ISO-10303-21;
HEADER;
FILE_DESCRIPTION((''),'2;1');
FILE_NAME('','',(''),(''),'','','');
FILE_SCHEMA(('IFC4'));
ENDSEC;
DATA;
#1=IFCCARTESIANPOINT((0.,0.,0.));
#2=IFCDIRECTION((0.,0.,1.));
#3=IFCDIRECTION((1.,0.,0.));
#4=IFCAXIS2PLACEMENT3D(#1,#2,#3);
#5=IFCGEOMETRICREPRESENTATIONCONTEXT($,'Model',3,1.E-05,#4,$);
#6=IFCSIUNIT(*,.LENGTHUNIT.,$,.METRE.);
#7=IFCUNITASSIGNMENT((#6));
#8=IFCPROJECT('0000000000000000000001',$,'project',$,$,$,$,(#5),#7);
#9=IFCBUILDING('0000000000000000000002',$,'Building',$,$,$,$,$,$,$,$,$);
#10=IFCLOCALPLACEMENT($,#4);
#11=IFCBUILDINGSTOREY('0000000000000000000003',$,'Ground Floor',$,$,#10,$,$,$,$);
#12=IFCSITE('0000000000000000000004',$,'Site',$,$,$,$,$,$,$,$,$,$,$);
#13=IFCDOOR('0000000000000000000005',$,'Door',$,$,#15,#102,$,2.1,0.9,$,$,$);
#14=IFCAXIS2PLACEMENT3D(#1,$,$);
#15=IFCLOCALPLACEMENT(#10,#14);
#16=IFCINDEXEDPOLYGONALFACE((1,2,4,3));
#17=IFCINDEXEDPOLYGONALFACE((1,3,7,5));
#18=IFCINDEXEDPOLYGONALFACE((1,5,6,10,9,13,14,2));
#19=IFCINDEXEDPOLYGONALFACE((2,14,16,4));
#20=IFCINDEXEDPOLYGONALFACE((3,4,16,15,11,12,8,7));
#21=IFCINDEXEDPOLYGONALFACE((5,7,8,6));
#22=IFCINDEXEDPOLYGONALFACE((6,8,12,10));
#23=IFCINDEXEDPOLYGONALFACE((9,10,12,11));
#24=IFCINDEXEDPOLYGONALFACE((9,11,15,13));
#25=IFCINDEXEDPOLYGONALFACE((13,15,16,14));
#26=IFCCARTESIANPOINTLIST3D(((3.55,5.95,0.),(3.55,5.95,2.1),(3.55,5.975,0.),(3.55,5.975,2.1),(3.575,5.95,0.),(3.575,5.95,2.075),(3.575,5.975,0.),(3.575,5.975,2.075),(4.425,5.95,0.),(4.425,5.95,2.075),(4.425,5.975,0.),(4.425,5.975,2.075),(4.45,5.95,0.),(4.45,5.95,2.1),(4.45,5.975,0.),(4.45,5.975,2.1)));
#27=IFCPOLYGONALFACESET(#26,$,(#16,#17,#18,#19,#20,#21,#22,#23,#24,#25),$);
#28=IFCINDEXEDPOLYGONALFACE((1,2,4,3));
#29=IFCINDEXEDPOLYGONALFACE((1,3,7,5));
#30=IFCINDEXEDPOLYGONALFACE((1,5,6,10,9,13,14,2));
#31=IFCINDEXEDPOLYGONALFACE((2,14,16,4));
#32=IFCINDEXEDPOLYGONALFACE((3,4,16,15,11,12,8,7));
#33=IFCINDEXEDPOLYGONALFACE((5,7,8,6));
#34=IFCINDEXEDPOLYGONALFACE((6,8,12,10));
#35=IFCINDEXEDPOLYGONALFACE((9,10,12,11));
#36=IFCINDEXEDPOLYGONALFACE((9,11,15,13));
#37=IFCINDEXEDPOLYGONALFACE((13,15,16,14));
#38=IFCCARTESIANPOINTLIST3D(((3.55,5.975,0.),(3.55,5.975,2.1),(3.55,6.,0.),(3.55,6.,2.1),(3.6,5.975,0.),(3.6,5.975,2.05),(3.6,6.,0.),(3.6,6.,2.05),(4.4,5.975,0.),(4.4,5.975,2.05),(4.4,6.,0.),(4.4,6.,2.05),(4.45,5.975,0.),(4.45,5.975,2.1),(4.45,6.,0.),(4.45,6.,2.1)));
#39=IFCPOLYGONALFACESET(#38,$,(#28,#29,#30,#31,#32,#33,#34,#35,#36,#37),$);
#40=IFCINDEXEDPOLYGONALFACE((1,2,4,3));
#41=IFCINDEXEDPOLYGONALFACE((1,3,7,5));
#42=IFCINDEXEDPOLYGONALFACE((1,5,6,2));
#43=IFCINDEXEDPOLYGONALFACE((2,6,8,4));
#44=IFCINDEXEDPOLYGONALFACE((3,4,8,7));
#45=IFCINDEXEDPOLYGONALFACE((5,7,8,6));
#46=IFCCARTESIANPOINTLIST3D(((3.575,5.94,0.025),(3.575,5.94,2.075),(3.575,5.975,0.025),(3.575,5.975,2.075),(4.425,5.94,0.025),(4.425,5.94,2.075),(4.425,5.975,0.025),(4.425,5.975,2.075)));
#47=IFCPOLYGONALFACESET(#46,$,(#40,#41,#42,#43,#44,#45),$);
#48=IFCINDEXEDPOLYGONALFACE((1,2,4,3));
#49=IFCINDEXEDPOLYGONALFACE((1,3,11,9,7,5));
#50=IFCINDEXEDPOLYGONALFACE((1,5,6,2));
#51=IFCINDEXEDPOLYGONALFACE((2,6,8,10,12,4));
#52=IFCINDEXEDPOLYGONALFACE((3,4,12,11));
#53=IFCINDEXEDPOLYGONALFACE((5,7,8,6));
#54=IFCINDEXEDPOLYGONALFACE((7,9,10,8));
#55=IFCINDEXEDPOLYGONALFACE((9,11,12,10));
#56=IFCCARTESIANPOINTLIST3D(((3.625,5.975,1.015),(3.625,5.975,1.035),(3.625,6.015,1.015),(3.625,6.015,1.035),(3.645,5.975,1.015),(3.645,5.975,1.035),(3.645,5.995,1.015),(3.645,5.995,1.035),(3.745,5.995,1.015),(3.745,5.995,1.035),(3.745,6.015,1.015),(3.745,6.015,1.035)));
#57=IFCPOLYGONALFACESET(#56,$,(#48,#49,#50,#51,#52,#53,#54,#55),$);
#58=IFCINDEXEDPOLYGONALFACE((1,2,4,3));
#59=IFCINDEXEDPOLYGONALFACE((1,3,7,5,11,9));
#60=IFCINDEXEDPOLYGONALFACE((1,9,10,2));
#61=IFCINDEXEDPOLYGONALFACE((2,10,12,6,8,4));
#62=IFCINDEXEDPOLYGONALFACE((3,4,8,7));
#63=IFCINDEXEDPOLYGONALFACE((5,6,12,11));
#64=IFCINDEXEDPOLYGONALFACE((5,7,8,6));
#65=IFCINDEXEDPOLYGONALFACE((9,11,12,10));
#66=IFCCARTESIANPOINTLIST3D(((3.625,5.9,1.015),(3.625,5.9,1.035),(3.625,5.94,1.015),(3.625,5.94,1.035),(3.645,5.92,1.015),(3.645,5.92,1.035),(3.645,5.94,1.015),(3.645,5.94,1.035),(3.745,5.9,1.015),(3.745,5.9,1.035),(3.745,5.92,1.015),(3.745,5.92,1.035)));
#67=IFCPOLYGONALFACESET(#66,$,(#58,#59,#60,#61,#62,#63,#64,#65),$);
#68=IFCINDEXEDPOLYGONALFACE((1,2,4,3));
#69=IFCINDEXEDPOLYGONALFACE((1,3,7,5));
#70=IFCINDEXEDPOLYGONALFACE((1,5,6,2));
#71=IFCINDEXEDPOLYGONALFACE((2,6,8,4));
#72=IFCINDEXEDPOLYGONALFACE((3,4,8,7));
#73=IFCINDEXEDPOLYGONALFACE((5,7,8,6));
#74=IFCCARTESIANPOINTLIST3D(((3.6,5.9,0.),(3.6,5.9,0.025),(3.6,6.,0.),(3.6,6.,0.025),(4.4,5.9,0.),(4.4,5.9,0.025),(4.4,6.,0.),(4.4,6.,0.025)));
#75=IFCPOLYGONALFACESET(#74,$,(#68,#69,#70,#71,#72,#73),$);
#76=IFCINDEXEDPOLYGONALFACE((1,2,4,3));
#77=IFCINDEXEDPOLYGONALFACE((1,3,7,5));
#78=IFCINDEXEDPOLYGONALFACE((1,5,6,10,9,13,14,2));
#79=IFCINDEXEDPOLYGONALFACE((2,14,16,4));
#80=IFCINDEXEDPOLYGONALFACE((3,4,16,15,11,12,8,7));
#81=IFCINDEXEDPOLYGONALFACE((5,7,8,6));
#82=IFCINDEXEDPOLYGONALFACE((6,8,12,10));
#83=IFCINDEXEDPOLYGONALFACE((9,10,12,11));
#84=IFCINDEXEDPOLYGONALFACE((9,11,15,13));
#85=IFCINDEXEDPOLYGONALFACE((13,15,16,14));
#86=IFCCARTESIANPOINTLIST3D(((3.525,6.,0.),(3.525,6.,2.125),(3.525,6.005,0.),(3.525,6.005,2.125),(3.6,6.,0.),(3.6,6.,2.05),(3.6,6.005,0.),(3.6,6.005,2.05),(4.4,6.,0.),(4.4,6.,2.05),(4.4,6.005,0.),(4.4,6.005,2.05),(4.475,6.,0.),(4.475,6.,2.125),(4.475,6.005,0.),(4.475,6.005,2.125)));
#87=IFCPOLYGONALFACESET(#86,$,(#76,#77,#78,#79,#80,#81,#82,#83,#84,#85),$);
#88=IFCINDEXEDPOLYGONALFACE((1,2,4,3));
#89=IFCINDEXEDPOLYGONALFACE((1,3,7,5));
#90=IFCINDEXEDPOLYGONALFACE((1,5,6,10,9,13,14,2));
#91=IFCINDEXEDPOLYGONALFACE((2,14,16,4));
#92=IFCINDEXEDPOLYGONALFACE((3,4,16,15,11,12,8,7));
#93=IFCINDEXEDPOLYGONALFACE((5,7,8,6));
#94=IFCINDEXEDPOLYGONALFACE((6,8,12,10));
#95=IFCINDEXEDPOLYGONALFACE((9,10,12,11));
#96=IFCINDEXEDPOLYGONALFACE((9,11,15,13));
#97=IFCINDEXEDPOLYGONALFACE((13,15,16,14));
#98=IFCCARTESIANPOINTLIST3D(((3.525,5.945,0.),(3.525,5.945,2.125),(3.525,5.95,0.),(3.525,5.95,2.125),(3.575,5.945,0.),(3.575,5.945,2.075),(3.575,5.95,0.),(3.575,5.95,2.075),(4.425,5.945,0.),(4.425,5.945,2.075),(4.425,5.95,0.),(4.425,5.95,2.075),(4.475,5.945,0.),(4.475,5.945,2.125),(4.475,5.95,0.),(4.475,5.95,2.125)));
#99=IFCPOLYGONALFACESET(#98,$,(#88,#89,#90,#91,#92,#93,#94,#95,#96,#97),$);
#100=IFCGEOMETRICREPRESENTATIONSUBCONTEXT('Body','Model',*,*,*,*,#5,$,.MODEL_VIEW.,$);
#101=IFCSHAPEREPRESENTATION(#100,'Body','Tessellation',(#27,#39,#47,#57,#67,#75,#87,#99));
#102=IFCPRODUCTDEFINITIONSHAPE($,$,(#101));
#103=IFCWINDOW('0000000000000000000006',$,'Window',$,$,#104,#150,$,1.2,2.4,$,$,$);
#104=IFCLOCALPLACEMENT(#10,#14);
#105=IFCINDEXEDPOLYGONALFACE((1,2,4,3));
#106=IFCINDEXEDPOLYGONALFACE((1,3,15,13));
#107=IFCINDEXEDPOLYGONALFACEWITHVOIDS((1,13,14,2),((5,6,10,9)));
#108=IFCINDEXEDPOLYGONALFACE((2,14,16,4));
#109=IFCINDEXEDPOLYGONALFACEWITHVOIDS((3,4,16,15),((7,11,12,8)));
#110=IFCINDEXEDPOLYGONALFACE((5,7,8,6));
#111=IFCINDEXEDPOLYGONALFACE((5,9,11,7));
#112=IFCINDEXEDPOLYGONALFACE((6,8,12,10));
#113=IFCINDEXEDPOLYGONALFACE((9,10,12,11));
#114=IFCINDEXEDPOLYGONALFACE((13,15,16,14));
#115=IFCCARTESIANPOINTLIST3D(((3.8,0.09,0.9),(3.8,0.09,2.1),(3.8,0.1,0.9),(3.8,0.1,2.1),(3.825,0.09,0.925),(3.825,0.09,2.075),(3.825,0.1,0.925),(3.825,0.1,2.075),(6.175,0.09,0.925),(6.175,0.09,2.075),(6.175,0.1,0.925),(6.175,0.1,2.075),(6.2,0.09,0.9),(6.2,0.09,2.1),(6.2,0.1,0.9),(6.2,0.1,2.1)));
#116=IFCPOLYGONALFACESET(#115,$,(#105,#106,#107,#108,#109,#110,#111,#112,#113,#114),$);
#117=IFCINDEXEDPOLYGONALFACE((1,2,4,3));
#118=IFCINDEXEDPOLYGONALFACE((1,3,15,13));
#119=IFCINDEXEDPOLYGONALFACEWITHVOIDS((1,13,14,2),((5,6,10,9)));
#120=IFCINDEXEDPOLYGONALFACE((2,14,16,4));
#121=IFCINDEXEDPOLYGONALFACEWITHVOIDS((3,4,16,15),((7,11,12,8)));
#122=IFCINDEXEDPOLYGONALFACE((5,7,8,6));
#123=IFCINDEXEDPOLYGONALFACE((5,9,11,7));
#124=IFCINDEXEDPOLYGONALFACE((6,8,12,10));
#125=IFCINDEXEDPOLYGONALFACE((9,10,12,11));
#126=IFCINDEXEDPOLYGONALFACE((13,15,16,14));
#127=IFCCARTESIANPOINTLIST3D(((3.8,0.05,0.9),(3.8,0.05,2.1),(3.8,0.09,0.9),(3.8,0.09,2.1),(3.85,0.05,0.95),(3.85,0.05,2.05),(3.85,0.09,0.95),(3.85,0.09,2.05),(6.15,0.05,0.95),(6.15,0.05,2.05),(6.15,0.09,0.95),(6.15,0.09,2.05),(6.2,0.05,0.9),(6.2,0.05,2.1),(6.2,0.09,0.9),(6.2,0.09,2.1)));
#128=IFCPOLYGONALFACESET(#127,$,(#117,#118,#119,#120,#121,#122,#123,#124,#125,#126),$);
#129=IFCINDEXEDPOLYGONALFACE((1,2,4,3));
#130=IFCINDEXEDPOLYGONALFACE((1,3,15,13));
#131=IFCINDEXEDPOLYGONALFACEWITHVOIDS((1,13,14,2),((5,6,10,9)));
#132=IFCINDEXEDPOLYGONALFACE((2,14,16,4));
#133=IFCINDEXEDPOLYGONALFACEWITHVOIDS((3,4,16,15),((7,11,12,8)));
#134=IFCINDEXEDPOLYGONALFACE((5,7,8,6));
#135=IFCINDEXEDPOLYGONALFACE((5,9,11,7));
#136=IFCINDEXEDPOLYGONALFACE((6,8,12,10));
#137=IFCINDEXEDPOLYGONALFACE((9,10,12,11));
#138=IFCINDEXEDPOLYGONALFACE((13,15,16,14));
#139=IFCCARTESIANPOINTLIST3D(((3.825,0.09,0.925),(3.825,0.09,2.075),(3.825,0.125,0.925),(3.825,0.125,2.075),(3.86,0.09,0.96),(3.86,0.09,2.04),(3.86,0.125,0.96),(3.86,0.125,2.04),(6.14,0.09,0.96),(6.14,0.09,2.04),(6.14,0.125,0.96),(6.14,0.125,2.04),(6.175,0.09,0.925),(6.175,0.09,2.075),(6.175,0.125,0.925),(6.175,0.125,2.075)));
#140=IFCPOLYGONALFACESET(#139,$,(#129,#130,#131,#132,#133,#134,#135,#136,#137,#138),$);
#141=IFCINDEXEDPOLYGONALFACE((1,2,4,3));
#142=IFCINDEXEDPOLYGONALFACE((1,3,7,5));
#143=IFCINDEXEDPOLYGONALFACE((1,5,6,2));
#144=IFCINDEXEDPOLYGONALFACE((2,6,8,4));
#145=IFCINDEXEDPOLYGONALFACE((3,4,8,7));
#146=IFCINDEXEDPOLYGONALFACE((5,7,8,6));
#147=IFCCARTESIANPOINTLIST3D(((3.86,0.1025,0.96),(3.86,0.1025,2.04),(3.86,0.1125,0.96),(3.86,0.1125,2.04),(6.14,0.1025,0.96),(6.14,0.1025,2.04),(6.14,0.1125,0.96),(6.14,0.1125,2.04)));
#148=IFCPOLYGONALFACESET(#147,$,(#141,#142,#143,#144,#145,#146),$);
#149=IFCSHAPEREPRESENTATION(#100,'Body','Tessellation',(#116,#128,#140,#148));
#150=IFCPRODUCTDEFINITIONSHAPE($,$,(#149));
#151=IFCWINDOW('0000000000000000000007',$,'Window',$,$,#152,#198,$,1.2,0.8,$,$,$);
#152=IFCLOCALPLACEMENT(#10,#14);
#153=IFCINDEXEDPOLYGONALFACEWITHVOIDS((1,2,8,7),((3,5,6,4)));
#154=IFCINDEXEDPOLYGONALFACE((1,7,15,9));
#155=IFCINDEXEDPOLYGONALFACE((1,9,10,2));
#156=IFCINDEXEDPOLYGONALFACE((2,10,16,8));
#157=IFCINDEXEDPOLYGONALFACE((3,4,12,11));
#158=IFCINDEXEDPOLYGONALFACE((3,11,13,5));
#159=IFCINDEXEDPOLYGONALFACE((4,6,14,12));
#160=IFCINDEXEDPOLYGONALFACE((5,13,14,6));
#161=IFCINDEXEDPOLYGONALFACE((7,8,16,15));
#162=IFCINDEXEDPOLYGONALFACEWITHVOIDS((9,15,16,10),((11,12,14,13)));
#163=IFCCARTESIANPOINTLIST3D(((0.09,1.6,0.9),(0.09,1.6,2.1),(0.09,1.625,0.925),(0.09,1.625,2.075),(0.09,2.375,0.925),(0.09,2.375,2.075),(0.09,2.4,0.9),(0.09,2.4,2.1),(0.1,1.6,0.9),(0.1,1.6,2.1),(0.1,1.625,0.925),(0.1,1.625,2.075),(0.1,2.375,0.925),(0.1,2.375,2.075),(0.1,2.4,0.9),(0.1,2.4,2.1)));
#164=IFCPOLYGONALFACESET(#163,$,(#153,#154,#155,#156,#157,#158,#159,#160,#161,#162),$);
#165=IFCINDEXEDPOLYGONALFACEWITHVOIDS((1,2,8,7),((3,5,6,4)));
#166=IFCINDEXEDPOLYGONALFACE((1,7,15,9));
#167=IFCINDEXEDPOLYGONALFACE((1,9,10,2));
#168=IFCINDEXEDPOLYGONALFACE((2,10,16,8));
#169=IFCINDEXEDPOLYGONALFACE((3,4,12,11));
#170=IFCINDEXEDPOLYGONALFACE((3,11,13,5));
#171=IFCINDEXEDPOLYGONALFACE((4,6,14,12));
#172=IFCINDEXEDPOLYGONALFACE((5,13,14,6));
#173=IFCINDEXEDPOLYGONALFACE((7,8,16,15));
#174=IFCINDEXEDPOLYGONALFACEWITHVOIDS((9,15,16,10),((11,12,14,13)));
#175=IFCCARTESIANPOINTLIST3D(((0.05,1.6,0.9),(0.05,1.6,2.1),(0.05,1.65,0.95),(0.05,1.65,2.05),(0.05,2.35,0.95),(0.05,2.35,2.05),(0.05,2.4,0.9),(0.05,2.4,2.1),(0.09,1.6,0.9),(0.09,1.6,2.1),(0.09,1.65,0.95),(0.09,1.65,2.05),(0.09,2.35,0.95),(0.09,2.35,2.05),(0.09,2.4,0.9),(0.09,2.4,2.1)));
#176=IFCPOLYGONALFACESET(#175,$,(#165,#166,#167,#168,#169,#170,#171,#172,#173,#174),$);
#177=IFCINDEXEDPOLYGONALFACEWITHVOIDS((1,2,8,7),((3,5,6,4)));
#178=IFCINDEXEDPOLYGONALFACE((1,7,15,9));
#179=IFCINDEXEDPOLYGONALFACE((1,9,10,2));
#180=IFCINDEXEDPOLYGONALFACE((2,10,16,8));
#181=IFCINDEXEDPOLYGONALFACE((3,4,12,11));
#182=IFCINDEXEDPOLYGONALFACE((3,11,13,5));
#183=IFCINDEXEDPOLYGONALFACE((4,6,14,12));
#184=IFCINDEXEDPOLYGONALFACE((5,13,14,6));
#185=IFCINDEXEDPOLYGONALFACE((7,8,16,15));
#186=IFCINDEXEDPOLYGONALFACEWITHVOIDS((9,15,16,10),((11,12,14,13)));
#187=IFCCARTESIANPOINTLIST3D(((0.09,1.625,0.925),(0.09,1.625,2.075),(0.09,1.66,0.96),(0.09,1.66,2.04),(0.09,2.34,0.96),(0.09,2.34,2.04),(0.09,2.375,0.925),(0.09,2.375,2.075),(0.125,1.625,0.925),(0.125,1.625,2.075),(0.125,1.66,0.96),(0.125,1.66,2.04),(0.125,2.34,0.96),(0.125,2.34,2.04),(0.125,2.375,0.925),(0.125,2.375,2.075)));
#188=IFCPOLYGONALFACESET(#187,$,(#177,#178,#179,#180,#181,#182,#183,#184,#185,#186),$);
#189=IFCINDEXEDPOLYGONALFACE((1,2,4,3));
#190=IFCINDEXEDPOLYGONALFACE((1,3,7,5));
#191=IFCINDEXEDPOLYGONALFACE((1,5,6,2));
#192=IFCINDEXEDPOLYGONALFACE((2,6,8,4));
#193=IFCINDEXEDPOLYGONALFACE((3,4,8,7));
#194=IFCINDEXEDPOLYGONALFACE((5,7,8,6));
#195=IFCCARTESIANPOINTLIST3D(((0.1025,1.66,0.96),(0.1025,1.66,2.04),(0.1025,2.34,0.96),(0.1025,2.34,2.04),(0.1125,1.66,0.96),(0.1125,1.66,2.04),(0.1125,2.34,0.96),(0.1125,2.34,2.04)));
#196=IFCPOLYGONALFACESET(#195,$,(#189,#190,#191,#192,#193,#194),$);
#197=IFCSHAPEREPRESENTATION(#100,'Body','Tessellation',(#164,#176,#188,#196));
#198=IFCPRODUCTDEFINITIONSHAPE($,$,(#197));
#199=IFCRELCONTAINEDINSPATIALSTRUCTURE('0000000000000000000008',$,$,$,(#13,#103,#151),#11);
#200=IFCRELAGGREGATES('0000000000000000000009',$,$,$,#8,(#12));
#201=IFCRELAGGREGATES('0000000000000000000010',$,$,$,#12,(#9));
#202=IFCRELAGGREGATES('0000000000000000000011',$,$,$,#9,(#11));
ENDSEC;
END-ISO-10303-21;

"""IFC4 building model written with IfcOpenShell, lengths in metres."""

from ifc_helpers import new_model, si_unit, frame, origin_with_axes, place, context, subcontext, project, spatial, line, indexed_curve, outline, extrude, element, save


model = new_model("IFC4")

# Units and contexts
model_context = context("Model", 3, precision=1e-05, world=origin_with_axes())
body_context = subcontext(model_context, "Body", "Model", "MODEL_VIEW")
ifc_project = project(units=[si_unit("LENGTHUNIT", "METRE")], contexts=[model_context])

# Site, building, storey
site = spatial("IfcSite", under=ifc_project, Name="Site")
building = spatial("IfcBuilding", under=site, Name="Building")
storey_placement = place(None, origin_with_axes())
storey = spatial("IfcBuildingStorey", under=building, at=storey_placement, Name="Ground Floor")

# Door
door_1_placement = place(storey_placement, frame((4.45, 6.0, 0.0), z_axis=(0.0, 0.0, 1.0), x_axis=(-1.0, 0.0, 0.0)))
element("IfcDoor", 1, at=door_1_placement, inside=storey, Name="Door", OverallHeight=2.1, OverallWidth=0.9, context=body_context, shape_type="SweptSolid", body=[
    extrude(outline(indexed_curve([(0.0, 0.0), (0.0, 2.1), (0.9, 2.1), (0.9, 0.0), (0.875, 0.0), (0.875, 2.075), (0.025, 2.075), (0.025, 0.0)], segments=[line(1, 2, 3, 4, 5, 6, 7, 8, 1)])), frame((0.0, 0.025, 0.0), z_axis=(0.0, -1.0, 0.0), x_axis=(1.0, 0.0, 0.0)), (0.0, 0.0, -1.0), 0.025),
    extrude(outline(indexed_curve([(0.0, 0.0), (0.0, 2.1), (0.9, 2.1), (0.9, 0.0), (0.85, 0.0), (0.85, 2.05), (0.05, 2.05), (0.05, 0.0)], segments=[line(1, 2, 3, 4, 5, 6, 7, 8, 1)])), frame((0.0, 0.0, 0.0), z_axis=(0.0, -1.0, 0.0), x_axis=(1.0, 0.0, 0.0)), (0.0, 0.0, -1.0), 0.025),
    extrude(outline(indexed_curve([(0.0, 0.0), (0.85, 0.0), (0.85, 0.035), (0.0, 0.035)], segments=[line(1, 2, 3, 4, 1)])), frame((0.025, 0.025, 0.025), z_axis=(0.0, 0.0, 1.0), x_axis=(1.0, 0.0, 0.0)), (0.0, 0.0, 1.0), 2.05),
    extrude(outline(indexed_curve([(0.0, 0.0), (0.0, -0.04), (-0.12, -0.04), (-0.12, -0.02), (-0.02, -0.02), (-0.02, 0.0)], segments=[line(1, 2, 3, 4, 5, 6, 1)])), frame((0.825, 0.025, 1.015), z_axis=(0.0, 0.0, 1.0), x_axis=(1.0, 0.0, 0.0)), (0.0, 0.0, 1.0), 0.02),
    extrude(outline(indexed_curve([(0.0, 0.0), (0.0, 0.04), (-0.12, 0.04), (-0.12, 0.02), (-0.02, 0.02), (-0.02, 0.0)], segments=[line(1, 2, 3, 4, 5, 6, 1)])), frame((0.825, 0.06, 1.015), z_axis=(0.0, 0.0, 1.0), x_axis=(1.0, 0.0, 0.0)), (0.0, 0.0, 1.0), 0.02),
    extrude(outline(indexed_curve([(0.0, 0.0), (0.8, 0.0), (0.8, 0.1), (0.0, 0.1)], segments=[line(1, 2, 3, 4, 1)])), frame((0.05, 0.0, 0.0), z_axis=(0.0, 0.0, 1.0), x_axis=(1.0, 0.0, 0.0)), (0.0, 0.0, 1.0), 0.025),
    extrude(outline(indexed_curve([(0.0, 0.0), (0.0, 2.125), (0.95, 2.125), (0.95, 0.0), (0.875, 0.0), (0.875, 2.05), (0.075, 2.05), (0.075, 0.0)], segments=[line(1, 2, 3, 4, 5, 6, 7, 8, 1)])), frame((-0.025, -0.005, 0.0), z_axis=(0.0, -1.0, 0.0), x_axis=(1.0, 0.0, 0.0)), (0.0, 0.0, -1.0), 0.005),
    extrude(outline(indexed_curve([(0.0, 0.0), (0.0, 2.125), (0.95, 2.125), (0.95, 0.0), (0.9, 0.0), (0.9, 2.075), (0.05, 2.075), (0.05, 0.0)], segments=[line(1, 2, 3, 4, 5, 6, 7, 8, 1)])), frame((-0.025, 0.05, 0.0), z_axis=(0.0, -1.0, 0.0), x_axis=(1.0, 0.0, 0.0)), (0.0, 0.0, -1.0), 0.005),
])

# Windows
window_1_placement = place(storey_placement, frame((3.8, 0.0, 0.9), z_axis=(0.0, 0.0, 1.0), x_axis=(1.0, 0.0, 0.0)))
element("IfcWindow", 2, at=window_1_placement, inside=storey, Name="Window", OverallHeight=1.2, OverallWidth=2.4, context=body_context, shape_type="SweptSolid", body=[
    extrude(outline(indexed_curve([(0.0, 0.0), (2.4, 0.0), (2.4, 1.2), (0.0, 1.2)], segments=[line(1, 2, 3, 4, 1)]), holes=[indexed_curve([(0.025, 0.025), (2.375, 0.025), (2.375, 1.175), (0.025, 1.175)], segments=[line(1, 2, 3, 4, 1)])]), frame((0.0, 0.09, 0.0), z_axis=(0.0, -1.0, 0.0), x_axis=(1.0, 0.0, 0.0)), (0.0, 0.0, -1.0), 0.01),
    extrude(outline(indexed_curve([(0.0, 0.0), (2.4, 0.0), (2.4, 1.2), (0.0, 1.2)], segments=[line(1, 2, 3, 4, 1)]), holes=[indexed_curve([(0.05, 0.05), (2.35, 0.05), (2.35, 1.15), (0.05, 1.15)], segments=[line(1, 2, 3, 4, 1)])]), frame((0.0, 0.05, 0.0), z_axis=(0.0, -1.0, 0.0), x_axis=(1.0, 0.0, 0.0)), (0.0, 0.0, -1.0), 0.04),
    extrude(outline(indexed_curve([(0.0, 0.0), (2.35, 0.0), (2.35, 1.15), (0.0, 1.15)], segments=[line(1, 2, 3, 4, 1)]), holes=[indexed_curve([(0.035, 0.035), (2.315, 0.035), (2.315, 1.115), (0.035, 1.115)], segments=[line(1, 2, 3, 4, 1)])]), frame((0.025, 0.09, 0.025), z_axis=(0.0, -1.0, 0.0), x_axis=(1.0, 0.0, 0.0)), (0.0, 0.0, -1.0), 0.035),
    extrude(outline(indexed_curve([(0.035, 0.035), (2.315, 0.035), (2.315, 1.115), (0.035, 1.115)], segments=[line(1, 2, 3, 4, 1)])), frame((0.025, 0.1025, 0.025), z_axis=(0.0, -1.0, 0.0), x_axis=(1.0, 0.0, 0.0)), (0.0, 0.0, -1.0), 0.01),
])
window_2_placement = place(storey_placement, frame((0.0, 2.4, 0.9), z_axis=(0.0, 0.0, 1.0), x_axis=(0.0, -1.0, 0.0)))
element("IfcWindow", 3, at=window_2_placement, inside=storey, Name="Window", OverallHeight=1.2, OverallWidth=0.8, context=body_context, shape_type="SweptSolid", body=[
    extrude(outline(indexed_curve([(0.0, 0.0), (0.8, 0.0), (0.8, 1.2), (0.0, 1.2)], segments=[line(1, 2, 3, 4, 1)]), holes=[indexed_curve([(0.025, 0.025), (0.775, 0.025), (0.775, 1.175), (0.025, 1.175)], segments=[line(1, 2, 3, 4, 1)])]), frame((0.0, 0.09, 0.0), z_axis=(0.0, -1.0, 0.0), x_axis=(1.0, 0.0, 0.0)), (0.0, 0.0, -1.0), 0.01),
    extrude(outline(indexed_curve([(0.0, 0.0), (0.8, 0.0), (0.8, 1.2), (0.0, 1.2)], segments=[line(1, 2, 3, 4, 1)]), holes=[indexed_curve([(0.05, 0.05), (0.75, 0.05), (0.75, 1.15), (0.05, 1.15)], segments=[line(1, 2, 3, 4, 1)])]), frame((0.0, 0.05, 0.0), z_axis=(0.0, -1.0, 0.0), x_axis=(1.0, 0.0, 0.0)), (0.0, 0.0, -1.0), 0.04),
    extrude(outline(indexed_curve([(0.0, 0.0), (0.75, 0.0), (0.75, 1.15), (0.0, 1.15)], segments=[line(1, 2, 3, 4, 1)]), holes=[indexed_curve([(0.035, 0.035), (0.715, 0.035), (0.715, 1.115), (0.035, 1.115)], segments=[line(1, 2, 3, 4, 1)])]), frame((0.025, 0.09, 0.025), z_axis=(0.0, -1.0, 0.0), x_axis=(1.0, 0.0, 0.0)), (0.0, 0.0, -1.0), 0.035),
    extrude(outline(indexed_curve([(0.035, 0.035), (0.715, 0.035), (0.715, 1.115), (0.035, 1.115)], segments=[line(1, 2, 3, 4, 1)])), frame((0.025, 0.1025, 0.025), z_axis=(0.0, -1.0, 0.0), x_axis=(1.0, 0.0, 0.0)), (0.0, 0.0, -1.0), 0.01),
])

save(model, "model.ifc")
